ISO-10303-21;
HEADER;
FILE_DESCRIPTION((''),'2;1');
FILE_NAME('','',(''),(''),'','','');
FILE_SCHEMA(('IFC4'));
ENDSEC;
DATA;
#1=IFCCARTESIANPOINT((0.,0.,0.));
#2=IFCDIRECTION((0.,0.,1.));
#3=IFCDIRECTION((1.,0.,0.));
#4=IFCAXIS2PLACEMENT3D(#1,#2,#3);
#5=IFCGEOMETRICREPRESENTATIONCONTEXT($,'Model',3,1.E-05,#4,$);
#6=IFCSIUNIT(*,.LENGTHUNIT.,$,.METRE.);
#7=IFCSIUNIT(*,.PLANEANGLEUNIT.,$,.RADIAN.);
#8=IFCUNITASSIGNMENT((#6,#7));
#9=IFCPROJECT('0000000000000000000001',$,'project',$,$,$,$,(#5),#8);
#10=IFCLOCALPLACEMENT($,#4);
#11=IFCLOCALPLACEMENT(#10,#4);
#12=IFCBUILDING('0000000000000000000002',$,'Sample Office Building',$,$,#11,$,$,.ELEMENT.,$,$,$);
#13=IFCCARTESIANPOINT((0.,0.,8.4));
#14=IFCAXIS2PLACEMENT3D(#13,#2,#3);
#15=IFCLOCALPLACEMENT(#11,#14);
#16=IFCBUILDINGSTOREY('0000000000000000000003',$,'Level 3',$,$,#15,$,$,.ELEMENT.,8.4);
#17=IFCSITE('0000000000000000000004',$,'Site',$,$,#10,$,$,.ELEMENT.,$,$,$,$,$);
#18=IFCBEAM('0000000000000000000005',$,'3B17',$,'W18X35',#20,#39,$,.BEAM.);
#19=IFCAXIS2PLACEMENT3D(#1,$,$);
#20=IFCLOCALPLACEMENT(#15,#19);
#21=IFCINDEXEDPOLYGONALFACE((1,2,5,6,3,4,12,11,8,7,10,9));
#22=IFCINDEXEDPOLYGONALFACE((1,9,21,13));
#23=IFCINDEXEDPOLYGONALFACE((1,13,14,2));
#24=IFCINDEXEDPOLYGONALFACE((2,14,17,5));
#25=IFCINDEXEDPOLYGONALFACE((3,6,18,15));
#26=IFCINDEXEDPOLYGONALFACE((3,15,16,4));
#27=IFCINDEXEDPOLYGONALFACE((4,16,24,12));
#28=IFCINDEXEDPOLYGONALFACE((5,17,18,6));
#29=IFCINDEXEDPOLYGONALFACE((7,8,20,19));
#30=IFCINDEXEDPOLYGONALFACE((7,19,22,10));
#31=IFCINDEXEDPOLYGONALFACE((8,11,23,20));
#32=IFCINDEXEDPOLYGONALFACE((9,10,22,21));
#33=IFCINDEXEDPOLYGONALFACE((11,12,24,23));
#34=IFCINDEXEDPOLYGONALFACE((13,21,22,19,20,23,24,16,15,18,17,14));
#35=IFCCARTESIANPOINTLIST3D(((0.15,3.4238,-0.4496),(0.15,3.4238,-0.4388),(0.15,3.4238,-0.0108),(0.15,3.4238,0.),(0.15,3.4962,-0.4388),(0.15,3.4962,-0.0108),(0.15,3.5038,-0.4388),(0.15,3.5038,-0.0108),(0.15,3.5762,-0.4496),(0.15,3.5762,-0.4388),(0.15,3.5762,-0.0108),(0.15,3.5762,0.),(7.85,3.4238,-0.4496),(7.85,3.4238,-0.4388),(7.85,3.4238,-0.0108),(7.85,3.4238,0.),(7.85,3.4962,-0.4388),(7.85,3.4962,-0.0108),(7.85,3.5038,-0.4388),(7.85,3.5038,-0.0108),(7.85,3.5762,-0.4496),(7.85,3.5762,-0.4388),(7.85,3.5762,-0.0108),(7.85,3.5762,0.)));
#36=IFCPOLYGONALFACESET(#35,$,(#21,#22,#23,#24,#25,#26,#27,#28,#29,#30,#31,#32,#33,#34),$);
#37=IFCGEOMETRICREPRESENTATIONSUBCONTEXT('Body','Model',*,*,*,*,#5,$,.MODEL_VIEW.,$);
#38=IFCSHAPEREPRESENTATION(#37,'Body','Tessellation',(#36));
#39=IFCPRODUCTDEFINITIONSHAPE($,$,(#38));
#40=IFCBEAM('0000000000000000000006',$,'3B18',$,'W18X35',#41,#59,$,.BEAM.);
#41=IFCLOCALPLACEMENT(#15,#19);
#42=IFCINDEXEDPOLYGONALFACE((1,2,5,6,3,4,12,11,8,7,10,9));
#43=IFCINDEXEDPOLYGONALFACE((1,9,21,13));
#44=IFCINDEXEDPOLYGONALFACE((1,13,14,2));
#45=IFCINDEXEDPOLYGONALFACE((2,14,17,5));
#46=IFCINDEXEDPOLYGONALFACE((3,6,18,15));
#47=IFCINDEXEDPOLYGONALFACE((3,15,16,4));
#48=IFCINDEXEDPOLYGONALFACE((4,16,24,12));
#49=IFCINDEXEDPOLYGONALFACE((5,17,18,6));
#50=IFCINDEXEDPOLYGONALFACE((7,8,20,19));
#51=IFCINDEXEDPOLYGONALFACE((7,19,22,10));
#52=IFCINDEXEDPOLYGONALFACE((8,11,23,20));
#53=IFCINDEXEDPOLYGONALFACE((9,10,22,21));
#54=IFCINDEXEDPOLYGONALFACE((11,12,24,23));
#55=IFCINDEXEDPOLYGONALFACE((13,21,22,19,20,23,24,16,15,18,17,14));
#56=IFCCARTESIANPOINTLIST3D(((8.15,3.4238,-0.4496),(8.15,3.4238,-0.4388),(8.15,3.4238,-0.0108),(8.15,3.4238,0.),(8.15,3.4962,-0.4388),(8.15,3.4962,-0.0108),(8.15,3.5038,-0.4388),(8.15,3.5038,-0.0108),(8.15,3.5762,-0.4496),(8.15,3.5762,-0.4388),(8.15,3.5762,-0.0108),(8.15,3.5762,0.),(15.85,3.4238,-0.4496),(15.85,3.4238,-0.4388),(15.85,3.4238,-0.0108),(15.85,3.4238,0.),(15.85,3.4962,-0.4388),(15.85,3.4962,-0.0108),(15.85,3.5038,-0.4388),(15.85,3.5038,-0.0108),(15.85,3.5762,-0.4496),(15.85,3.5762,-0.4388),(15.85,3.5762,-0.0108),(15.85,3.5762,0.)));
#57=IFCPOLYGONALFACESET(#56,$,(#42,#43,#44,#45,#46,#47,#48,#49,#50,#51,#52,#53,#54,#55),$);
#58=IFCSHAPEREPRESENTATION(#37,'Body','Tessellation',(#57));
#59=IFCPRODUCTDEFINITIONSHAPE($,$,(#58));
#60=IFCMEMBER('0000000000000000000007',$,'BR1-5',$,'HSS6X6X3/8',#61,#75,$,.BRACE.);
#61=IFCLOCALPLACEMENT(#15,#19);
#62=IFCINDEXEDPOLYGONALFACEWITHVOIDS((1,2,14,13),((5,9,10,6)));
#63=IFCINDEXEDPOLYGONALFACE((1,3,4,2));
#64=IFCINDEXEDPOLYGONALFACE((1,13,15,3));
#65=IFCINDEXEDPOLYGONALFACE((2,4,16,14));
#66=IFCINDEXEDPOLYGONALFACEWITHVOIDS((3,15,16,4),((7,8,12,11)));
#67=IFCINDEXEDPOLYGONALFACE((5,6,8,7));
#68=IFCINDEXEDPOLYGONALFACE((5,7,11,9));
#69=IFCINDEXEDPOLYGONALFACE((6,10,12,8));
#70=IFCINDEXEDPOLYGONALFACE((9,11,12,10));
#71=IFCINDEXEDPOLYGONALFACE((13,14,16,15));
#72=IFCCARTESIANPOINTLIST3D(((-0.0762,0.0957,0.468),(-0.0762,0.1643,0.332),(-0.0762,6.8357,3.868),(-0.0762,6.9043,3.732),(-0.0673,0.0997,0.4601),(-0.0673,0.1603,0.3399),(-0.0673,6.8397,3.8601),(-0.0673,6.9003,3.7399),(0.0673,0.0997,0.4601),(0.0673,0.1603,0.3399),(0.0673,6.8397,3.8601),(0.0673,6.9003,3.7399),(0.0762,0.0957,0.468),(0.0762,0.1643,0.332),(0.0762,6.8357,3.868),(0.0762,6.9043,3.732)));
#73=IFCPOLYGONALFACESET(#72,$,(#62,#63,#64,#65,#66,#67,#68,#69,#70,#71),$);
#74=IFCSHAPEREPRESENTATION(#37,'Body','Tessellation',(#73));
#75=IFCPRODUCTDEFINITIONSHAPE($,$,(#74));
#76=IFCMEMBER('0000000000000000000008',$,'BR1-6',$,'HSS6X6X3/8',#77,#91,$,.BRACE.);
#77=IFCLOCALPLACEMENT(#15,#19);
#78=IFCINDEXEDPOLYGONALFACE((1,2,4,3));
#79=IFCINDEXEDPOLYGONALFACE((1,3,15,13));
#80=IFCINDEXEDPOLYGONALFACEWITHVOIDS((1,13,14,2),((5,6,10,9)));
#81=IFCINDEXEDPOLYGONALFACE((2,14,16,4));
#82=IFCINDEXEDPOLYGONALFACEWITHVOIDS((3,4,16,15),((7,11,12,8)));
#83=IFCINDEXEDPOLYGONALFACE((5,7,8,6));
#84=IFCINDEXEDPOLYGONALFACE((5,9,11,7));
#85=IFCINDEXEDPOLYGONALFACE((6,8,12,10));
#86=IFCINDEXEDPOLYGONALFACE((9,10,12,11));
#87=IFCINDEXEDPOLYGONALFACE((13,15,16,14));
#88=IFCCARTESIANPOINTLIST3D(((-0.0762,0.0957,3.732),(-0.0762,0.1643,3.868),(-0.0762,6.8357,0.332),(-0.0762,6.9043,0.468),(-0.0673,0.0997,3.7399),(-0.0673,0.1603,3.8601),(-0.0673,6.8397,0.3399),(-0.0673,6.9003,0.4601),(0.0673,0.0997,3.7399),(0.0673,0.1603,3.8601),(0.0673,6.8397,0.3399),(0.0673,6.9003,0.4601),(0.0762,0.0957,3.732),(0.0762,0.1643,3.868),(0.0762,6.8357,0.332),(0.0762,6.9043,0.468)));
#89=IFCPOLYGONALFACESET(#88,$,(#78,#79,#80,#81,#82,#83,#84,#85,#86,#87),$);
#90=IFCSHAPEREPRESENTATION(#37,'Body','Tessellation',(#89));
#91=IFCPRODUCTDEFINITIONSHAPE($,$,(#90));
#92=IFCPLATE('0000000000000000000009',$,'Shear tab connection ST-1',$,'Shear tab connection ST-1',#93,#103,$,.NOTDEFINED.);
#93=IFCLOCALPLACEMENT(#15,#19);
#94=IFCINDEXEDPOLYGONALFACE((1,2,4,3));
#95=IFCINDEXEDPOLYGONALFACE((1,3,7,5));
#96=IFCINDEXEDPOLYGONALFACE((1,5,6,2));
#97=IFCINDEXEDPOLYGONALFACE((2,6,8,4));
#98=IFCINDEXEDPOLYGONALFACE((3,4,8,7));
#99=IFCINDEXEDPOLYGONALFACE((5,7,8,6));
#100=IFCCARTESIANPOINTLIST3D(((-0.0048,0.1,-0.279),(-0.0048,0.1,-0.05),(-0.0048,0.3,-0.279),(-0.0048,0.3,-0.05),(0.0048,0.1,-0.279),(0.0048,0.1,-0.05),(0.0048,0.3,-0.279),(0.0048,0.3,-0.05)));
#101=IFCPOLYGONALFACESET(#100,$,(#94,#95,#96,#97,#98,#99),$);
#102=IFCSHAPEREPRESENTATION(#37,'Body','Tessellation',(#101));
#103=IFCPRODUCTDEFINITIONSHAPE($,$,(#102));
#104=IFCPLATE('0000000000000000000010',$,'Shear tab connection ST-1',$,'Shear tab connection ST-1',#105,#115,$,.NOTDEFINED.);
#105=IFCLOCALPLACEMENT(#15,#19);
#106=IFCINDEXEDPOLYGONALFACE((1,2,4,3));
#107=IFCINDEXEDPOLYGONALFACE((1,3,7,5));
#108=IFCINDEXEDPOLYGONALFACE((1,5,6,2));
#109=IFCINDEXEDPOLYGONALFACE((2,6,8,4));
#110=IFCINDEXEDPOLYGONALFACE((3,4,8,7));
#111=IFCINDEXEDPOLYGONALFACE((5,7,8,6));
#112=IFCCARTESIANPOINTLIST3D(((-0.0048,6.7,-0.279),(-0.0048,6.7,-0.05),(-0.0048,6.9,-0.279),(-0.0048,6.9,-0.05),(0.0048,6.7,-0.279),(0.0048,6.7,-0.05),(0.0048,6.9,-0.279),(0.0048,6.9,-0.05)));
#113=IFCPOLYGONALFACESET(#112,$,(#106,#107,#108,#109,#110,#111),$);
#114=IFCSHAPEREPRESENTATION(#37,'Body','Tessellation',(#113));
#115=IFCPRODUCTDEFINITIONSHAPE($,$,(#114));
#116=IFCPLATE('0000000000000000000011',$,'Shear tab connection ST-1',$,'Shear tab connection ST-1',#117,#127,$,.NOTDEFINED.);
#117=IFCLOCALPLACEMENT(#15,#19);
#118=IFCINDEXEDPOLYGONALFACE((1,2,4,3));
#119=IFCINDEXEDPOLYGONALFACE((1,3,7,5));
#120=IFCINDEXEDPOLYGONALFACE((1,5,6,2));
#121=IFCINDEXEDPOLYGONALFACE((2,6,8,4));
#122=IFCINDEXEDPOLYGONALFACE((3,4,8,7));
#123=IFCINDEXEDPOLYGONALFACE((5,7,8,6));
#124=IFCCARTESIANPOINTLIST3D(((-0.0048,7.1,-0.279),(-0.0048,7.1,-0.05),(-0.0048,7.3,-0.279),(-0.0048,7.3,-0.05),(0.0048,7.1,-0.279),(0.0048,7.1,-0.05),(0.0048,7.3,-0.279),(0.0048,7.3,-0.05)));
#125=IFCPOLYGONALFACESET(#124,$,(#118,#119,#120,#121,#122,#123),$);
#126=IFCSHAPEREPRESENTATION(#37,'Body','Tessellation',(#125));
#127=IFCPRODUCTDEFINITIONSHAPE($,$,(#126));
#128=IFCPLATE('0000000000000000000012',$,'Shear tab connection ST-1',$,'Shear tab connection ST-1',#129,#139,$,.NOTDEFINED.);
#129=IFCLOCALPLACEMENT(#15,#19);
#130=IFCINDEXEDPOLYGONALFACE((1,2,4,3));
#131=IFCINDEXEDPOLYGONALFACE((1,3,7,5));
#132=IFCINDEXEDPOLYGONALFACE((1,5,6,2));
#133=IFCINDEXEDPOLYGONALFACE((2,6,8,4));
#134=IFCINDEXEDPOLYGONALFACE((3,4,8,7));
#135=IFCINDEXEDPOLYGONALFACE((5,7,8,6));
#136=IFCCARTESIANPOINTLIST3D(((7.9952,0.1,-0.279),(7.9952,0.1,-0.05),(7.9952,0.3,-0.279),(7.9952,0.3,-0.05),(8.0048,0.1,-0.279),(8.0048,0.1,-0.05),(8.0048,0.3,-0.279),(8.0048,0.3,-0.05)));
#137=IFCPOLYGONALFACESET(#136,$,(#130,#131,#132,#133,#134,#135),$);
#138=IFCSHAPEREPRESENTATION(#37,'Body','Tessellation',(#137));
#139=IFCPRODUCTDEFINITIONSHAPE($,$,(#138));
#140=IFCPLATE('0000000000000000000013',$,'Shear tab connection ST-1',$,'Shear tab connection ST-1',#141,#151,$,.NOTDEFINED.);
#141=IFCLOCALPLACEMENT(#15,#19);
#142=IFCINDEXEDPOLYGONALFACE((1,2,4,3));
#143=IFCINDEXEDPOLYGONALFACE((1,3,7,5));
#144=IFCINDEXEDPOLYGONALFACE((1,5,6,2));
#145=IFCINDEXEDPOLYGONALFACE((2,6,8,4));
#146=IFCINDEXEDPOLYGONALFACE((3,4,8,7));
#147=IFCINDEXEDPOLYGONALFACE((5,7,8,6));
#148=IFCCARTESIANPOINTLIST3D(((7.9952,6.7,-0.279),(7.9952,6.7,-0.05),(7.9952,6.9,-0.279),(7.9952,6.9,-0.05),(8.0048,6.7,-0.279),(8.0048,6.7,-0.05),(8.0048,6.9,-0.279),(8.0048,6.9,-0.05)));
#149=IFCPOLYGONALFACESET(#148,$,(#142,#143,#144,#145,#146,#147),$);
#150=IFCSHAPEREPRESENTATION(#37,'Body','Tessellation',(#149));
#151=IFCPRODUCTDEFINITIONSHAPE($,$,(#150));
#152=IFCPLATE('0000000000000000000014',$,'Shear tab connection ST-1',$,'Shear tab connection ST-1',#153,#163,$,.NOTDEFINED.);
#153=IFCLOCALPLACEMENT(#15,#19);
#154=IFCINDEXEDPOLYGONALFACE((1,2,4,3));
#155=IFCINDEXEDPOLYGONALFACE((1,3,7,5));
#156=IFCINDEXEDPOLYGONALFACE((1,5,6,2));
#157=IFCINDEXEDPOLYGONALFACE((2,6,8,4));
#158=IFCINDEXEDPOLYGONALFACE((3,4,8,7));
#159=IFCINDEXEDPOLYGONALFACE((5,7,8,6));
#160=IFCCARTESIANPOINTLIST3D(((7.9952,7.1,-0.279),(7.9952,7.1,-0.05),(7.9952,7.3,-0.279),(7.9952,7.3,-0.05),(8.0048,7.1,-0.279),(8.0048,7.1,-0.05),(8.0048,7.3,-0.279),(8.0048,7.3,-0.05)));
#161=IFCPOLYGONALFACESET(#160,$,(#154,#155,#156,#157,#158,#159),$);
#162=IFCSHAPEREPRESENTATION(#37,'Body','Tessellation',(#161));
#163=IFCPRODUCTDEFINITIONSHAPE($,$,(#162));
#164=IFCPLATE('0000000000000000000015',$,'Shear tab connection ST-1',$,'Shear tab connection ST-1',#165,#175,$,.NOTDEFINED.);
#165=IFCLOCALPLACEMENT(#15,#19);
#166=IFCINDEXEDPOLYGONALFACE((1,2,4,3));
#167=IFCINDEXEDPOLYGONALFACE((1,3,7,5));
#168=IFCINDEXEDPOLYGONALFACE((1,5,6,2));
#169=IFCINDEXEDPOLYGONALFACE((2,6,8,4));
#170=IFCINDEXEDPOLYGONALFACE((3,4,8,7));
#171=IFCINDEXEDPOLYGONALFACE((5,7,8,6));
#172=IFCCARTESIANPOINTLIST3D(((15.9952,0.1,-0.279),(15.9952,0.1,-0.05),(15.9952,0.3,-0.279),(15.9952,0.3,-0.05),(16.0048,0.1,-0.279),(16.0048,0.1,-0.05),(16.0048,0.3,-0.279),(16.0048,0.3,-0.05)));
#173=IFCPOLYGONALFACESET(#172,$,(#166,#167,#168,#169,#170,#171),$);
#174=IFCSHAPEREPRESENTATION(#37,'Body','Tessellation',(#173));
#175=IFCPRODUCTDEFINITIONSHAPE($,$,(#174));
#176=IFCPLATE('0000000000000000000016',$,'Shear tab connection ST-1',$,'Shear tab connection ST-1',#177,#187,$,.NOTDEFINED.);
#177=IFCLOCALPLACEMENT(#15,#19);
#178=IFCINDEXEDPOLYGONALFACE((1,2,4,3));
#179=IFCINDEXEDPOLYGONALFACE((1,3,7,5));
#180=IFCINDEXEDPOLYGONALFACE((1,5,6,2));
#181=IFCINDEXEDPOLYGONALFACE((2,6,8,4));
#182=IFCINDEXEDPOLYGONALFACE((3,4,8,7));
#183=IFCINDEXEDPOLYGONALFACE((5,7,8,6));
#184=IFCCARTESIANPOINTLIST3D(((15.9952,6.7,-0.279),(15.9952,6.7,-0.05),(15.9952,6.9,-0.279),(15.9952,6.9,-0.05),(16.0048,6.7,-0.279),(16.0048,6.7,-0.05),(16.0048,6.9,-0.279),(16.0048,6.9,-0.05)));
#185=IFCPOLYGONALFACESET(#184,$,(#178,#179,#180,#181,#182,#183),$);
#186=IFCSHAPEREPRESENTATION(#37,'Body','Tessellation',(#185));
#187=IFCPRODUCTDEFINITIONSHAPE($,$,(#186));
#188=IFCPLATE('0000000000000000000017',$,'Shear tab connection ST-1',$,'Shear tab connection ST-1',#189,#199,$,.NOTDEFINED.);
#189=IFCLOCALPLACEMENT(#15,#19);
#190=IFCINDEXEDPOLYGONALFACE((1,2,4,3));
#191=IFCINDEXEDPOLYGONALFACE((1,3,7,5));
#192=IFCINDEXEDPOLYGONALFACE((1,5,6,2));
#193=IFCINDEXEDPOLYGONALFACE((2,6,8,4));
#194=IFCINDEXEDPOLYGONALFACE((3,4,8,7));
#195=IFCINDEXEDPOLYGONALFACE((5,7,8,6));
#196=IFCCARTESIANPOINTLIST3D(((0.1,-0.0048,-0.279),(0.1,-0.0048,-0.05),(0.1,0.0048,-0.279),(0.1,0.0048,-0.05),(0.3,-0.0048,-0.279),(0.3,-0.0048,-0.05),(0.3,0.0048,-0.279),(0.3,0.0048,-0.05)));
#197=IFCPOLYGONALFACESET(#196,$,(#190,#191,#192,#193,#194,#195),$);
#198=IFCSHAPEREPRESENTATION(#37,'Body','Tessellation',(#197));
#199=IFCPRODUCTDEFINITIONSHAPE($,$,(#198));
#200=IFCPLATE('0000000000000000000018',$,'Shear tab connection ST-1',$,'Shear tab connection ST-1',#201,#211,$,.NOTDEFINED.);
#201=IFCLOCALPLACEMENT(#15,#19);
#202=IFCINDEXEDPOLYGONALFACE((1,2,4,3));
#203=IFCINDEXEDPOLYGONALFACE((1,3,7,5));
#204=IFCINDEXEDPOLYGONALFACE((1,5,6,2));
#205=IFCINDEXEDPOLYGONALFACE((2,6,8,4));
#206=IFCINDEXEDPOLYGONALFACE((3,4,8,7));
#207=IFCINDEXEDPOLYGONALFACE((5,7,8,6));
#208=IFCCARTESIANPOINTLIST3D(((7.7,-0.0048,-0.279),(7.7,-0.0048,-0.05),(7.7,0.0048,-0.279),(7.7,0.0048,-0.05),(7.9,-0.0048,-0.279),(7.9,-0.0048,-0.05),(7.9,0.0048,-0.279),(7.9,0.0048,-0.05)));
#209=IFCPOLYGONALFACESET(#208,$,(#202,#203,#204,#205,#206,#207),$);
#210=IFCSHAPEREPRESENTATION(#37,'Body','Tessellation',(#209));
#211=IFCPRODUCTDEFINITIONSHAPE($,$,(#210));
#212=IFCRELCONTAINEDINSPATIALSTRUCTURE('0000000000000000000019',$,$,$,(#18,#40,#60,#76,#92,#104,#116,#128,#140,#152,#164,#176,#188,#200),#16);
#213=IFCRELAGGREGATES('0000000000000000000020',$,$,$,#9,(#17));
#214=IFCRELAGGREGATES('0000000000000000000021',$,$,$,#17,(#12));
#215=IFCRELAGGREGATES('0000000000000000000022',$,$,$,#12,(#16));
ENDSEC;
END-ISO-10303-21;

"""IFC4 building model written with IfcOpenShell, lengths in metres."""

from ifc_helpers import new_model, si_unit, frame, origin_with_axes, place, context, subcontext, project, spatial, rectangle, hollow_rectangle, i_section, extrude, element, save


model = new_model("IFC4")

# Units and contexts
model_context = context("Model", 3, precision=1e-05, world=origin_with_axes())
body_context = subcontext(model_context, "Body", "Model", "MODEL_VIEW")
ifc_project = project(units=[si_unit("LENGTHUNIT", "METRE"), si_unit("PLANEANGLEUNIT", "RADIAN")], contexts=[model_context])

# Site, building, storey
site_placement = place(None, origin_with_axes())
site = spatial("IfcSite", under=ifc_project, at=site_placement, Name="Site", CompositionType="ELEMENT")
building_placement = place(site_placement, origin_with_axes())
building = spatial("IfcBuilding", under=site, at=building_placement, Name="Sample Office Building", CompositionType="ELEMENT")
storey_placement = place(building_placement, frame((0.0, 0.0, 8.4), z_axis=(0.0, 0.0, 1.0), x_axis=(1.0, 0.0, 0.0)))
storey = spatial("IfcBuildingStorey", under=building, at=storey_placement, Name="Level 3", CompositionType="ELEMENT", Elevation=8.4)

# Beams
for number, where, z_axis, x_axis, name in (
    (1, (0.15, 3.5, 8.1752), (1.0, 0.0, 0.0), (0.0, 1.0, 0.0), "3B17"),
    (2, (8.15, 3.5, 8.1752), (1.0, 0.0, 0.0), (0.0, 1.0, 0.0), "3B18"),
):
    element("IfcBeam", number, at=place(None, frame(where, z_axis=z_axis, x_axis=x_axis)), inside=storey, Name=name, ObjectType="W18X35", PredefinedType="BEAM", context=body_context, shape_type="SweptSolid", body=[
        extrude(i_section(OverallWidth=0.1524, OverallDepth=0.4496, WebThickness=0.0076, FlangeThickness=0.0108), None, (0.0, 0.0, 1.0), 7.7),
    ])

# Members
for number, where, z_axis, x_axis, name in (
    (3, (0.0, 0.13, 8.8), (0.0, 0.892832, 0.45039), (-1.0, 0.0, 0.0), "BR1-5"),
    (4, (0.0, 6.87, 8.8), (0.0, -0.892832, 0.45039), (1.0, 0.0, 0.0), "BR1-6"),
):
    element("IfcMember", number, at=place(None, frame(where, z_axis=z_axis, x_axis=x_axis)), inside=storey, Name=name, ObjectType="HSS6X6X3/8", PredefinedType="BRACE", context=body_context, shape_type="SweptSolid", body=[
        extrude(hollow_rectangle(XDim=0.1524, YDim=0.1524, WallThickness=0.0089), None, (0.0, 0.0, 1.0), 7.549),
    ])

# Plates
plate_1_placement = place(None, frame((0.0, 0.2, 8.121), z_axis=(0.0, 0.0, 1.0), x_axis=(1.0, 0.0, 0.0)))
element("IfcPlate", 5, at=plate_1_placement, inside=storey, Name="Shear tab connection ST-1", ObjectType="Shear tab connection ST-1", PredefinedType="NOTDEFINED", context=body_context, shape_type="SweptSolid", body=[
    extrude(rectangle(XDim=0.0095, YDim=0.2), None, (0.0, 0.0, 1.0), 0.229),
])
for number, where, z_axis, x_axis, name in (
    (6, (0.0, 6.8, 8.121), (0.0, 0.0, 1.0), (1.0, 0.0, 0.0), "Shear tab connection ST-1"),
    (7, (0.0, 7.2, 8.121), (0.0, 0.0, 1.0), (1.0, 0.0, 0.0), "Shear tab connection ST-1"),
):
    element("IfcPlate", number, at=place(None, frame(where, z_axis=z_axis, x_axis=x_axis)), inside=storey, Name=name, ObjectType="Shear tab connection ST-1", PredefinedType="NOTDEFINED", context=body_context, shape_type="SweptSolid", body=[
        extrude(rectangle(XDim=0.0095, YDim=0.2), None, (0.0, 0.0, 1.0), 0.229),
    ])
plate_2_placement = place(None, frame((8.0, 0.2, 8.121), z_axis=(0.0, 0.0, 1.0), x_axis=(1.0, 0.0, 0.0)))
element("IfcPlate", 8, at=plate_2_placement, inside=storey, Name="Shear tab connection ST-1", ObjectType="Shear tab connection ST-1", PredefinedType="NOTDEFINED", context=body_context, shape_type="SweptSolid", body=[
    extrude(rectangle(XDim=0.0095, YDim=0.2), None, (0.0, 0.0, 1.0), 0.229),
])
for number, where, z_axis, x_axis, name in (
    (9, (8.0, 6.8, 8.121), (0.0, 0.0, 1.0), (1.0, 0.0, 0.0), "Shear tab connection ST-1"),
    (10, (8.0, 7.2, 8.121), (0.0, 0.0, 1.0), (1.0, 0.0, 0.0), "Shear tab connection ST-1"),
):
    element("IfcPlate", number, at=place(None, frame(where, z_axis=z_axis, x_axis=x_axis)), inside=storey, Name=name, ObjectType="Shear tab connection ST-1", PredefinedType="NOTDEFINED", context=body_context, shape_type="SweptSolid", body=[
        extrude(rectangle(XDim=0.0095, YDim=0.2), None, (0.0, 0.0, 1.0), 0.229),
    ])
plate_3_placement = place(None, frame((16.0, 0.2, 8.121), z_axis=(0.0, 0.0, 1.0), x_axis=(1.0, 0.0, 0.0)))
element("IfcPlate", 11, at=plate_3_placement, inside=storey, Name="Shear tab connection ST-1", ObjectType="Shear tab connection ST-1", PredefinedType="NOTDEFINED", context=body_context, shape_type="SweptSolid", body=[
    extrude(rectangle(XDim=0.0095, YDim=0.2), None, (0.0, 0.0, 1.0), 0.229),
])
plate_4_placement = place(None, frame((16.0, 6.8, 8.121), z_axis=(0.0, 0.0, 1.0), x_axis=(1.0, 0.0, 0.0)))
element("IfcPlate", 12, at=plate_4_placement, inside=storey, Name="Shear tab connection ST-1", ObjectType="Shear tab connection ST-1", PredefinedType="NOTDEFINED", context=body_context, shape_type="SweptSolid", body=[
    extrude(rectangle(XDim=0.0095, YDim=0.2), None, (0.0, 0.0, 1.0), 0.229),
])
plate_5_placement = place(None, frame((0.2, 0.0, 8.121), z_axis=(0.0, 0.0, 1.0), x_axis=(1.0, 0.0, 0.0)))
element("IfcPlate", 13, at=plate_5_placement, inside=storey, Name="Shear tab connection ST-1", ObjectType="Shear tab connection ST-1", PredefinedType="NOTDEFINED", context=body_context, shape_type="SweptSolid", body=[
    extrude(rectangle(XDim=0.2, YDim=0.0095), None, (0.0, 0.0, 1.0), 0.229),
])
plate_6_placement = place(None, frame((7.8, 0.0, 8.121), z_axis=(0.0, 0.0, 1.0), x_axis=(1.0, 0.0, 0.0)))
element("IfcPlate", 14, at=plate_6_placement, inside=storey, Name="Shear tab connection ST-1", ObjectType="Shear tab connection ST-1", PredefinedType="NOTDEFINED", context=body_context, shape_type="SweptSolid", body=[
    extrude(rectangle(XDim=0.2, YDim=0.0095), None, (0.0, 0.0, 1.0), 0.229),
])

save(model, "model.ifc")
